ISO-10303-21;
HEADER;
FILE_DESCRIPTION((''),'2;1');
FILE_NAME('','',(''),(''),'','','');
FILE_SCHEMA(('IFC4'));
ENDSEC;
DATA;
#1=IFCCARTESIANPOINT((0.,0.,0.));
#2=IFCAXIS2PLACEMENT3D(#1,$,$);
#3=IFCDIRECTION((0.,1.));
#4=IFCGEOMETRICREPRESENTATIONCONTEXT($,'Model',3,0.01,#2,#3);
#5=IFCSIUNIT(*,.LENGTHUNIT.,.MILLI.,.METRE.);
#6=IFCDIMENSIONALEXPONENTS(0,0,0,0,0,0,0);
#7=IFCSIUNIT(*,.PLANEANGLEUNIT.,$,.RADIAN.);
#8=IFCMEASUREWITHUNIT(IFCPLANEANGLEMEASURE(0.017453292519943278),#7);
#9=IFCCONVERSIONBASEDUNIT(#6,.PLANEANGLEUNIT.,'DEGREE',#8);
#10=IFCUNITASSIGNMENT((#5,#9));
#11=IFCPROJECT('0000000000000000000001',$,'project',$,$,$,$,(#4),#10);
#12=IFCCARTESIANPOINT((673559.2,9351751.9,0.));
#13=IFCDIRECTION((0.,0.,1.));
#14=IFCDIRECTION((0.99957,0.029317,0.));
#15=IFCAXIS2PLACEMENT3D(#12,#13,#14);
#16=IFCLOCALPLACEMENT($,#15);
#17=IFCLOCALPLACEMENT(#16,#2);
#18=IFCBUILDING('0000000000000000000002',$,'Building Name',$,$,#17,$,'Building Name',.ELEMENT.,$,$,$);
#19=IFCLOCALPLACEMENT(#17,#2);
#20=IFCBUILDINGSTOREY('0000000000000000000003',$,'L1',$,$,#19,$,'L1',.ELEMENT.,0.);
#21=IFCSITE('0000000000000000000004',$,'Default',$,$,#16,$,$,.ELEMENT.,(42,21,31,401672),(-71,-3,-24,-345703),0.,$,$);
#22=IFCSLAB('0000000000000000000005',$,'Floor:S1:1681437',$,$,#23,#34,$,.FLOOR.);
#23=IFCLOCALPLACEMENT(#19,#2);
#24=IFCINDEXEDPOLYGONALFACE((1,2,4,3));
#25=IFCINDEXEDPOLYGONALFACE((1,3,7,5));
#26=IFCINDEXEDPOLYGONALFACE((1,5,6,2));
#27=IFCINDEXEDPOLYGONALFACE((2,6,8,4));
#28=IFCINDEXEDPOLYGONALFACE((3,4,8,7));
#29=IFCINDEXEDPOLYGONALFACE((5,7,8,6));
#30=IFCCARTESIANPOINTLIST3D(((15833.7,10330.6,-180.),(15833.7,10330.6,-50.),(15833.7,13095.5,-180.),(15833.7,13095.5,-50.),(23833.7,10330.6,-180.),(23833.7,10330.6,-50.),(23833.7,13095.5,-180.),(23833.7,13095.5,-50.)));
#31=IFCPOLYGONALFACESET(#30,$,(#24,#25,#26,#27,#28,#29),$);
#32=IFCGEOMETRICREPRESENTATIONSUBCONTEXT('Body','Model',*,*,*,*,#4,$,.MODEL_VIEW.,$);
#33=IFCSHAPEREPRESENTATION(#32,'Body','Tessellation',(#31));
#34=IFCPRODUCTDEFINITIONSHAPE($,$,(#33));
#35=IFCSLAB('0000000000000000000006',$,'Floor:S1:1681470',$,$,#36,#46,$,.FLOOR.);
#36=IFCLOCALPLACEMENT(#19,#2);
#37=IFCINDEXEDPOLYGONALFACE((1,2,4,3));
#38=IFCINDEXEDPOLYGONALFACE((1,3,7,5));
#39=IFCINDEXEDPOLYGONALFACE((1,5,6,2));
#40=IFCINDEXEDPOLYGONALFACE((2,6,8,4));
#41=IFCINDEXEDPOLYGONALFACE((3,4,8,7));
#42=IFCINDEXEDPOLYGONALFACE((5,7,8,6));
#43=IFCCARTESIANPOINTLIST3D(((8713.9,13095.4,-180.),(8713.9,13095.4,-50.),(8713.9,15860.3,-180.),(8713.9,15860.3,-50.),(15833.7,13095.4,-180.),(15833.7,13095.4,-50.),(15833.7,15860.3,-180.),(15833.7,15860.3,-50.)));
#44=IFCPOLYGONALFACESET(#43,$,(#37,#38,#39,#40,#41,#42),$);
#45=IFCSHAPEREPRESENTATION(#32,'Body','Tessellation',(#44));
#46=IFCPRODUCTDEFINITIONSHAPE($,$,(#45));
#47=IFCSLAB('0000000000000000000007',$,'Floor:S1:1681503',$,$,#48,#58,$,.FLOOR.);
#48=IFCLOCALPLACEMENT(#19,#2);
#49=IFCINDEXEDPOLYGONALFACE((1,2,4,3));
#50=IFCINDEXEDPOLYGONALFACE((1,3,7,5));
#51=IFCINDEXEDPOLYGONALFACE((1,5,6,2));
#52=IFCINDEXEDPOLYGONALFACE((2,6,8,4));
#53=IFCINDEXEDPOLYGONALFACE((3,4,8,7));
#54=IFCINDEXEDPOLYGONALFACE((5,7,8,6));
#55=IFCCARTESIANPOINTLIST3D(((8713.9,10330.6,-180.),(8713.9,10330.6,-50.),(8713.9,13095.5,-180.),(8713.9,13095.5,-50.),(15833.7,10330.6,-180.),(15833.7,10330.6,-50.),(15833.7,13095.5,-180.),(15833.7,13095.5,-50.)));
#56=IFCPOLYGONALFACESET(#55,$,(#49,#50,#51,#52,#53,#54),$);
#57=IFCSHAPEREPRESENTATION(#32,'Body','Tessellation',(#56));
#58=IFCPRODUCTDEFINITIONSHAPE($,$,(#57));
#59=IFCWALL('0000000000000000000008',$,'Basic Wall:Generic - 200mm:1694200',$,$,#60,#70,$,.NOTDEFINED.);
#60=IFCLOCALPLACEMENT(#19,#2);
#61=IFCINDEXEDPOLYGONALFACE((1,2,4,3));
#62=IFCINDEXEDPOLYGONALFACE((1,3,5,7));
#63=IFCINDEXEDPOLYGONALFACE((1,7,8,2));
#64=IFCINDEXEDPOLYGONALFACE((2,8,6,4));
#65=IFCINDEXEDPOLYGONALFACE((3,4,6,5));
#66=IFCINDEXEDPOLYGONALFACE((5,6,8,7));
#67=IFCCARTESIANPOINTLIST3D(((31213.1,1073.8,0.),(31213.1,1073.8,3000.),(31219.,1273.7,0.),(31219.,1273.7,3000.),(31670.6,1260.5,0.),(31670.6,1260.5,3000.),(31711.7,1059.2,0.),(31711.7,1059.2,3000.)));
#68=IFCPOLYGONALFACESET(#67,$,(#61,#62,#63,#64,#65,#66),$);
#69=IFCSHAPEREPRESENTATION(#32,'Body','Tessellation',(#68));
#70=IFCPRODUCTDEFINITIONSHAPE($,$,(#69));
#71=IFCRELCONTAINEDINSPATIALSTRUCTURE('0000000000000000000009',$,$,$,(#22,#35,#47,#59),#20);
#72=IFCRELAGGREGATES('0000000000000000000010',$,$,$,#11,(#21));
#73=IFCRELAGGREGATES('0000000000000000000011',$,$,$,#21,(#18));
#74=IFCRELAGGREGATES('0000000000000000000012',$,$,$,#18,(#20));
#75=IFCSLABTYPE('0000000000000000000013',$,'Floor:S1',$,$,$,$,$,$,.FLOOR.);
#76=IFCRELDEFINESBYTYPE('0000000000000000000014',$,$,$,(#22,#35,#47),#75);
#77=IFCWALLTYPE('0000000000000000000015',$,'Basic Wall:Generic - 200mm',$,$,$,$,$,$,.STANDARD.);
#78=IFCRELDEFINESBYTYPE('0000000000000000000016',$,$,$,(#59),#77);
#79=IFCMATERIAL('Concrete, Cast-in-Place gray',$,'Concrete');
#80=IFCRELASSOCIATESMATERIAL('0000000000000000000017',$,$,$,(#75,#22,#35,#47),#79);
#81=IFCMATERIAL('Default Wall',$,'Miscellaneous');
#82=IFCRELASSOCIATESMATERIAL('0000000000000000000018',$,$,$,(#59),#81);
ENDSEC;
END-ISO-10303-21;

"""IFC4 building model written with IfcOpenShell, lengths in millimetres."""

from ifc_helpers import new_model, entity, si_unit, converted_unit, direction, frame, origin, place, context, subcontext, project, spatial, indexed_curve, outline, extrude, material, type_object, element, save


model = new_model("IFC4")

# Units and contexts
model_context = context("Model", 3, precision=0.01, world=origin(), true_north=direction((0.0, 1.0)))
body_context = subcontext(model_context, "Body", "Model", "MODEL_VIEW")
ifc_project = project(units=[si_unit("LENGTHUNIT", "METRE", prefix="MILLI"), converted_unit("PLANEANGLEUNIT", "DEGREE", entity("IfcPlaneAngleMeasure", 0.017453292519943278), si_unit("PLANEANGLEUNIT", "RADIAN"), dimensions=[0, 0, 0, 0, 0, 0, 0])], contexts=[model_context])

# Site, building, storey
site_placement = place(None, frame((673559.2, 9351751.9, 0.0), z_axis=(0.0, 0.0, 1.0), x_axis=(0.99957, 0.029317, 0.0)))
site = spatial("IfcSite", under=ifc_project, at=site_placement, Name="Default", CompositionType="ELEMENT", RefLatitude=(42, 21, 31, 401672), RefLongitude=(-71, -3, -24, -345703), RefElevation=0.0)
building_placement = place(site_placement, origin())
building = spatial("IfcBuilding", under=site, at=building_placement, Name="Building Name", LongName="Building Name", CompositionType="ELEMENT")
storey_placement = place(building_placement, origin())
storey = spatial("IfcBuildingStorey", under=building, at=storey_placement, Name="L1", LongName="L1", CompositionType="ELEMENT", Elevation=0.0)

# Shared definitions
ifc_material_1 = material(Name="Concrete, Cast-in-Place gray", Category="Concrete")

# Slabs
slab_type_1 = type_object("IfcSlabType", Name="Floor:S1", PredefinedType="FLOOR", material=ifc_material_1)
slab_1_placement = place(storey_placement, origin())
element("IfcSlab", 1, at=slab_1_placement, inside=storey, type_object=slab_type_1, material=ifc_material_1, Name="Floor:S1:1681437", PredefinedType="FLOOR", context=body_context, shape_type="SweptSolid", body=[
    extrude(outline(indexed_curve([(-1382.4, -4000.0), (1382.4, -4000.0), (1382.4, 4000.0), (-1382.4, 4000.0), (-1382.4, -4000.0)], self_intersect=False)), frame((19833.7, 11713.0, -50.0), z_axis=(0.0, 0.0, -1.0), x_axis=(0.0, 1.0, 0.0)), (0.0, 0.0, 1.0), 130.0),
])
slab_2_placement = place(storey_placement, origin())
element("IfcSlab", 2, at=slab_2_placement, inside=storey, type_object=slab_type_1, material=ifc_material_1, Name="Floor:S1:1681470", PredefinedType="FLOOR", context=body_context, shape_type="SweptSolid", body=[
    extrude(outline(indexed_curve([(-1382.4, -3559.9), (1382.4, -3559.9), (1382.4, 3559.9), (-1382.4, 3559.9), (-1382.4, -3559.9)], self_intersect=False)), frame((12273.8, 14477.9, -50.0), z_axis=(0.0, 0.0, -1.0), x_axis=(0.0, 1.0, 0.0)), (0.0, 0.0, 1.0), 130.0),
])
slab_3_placement = place(storey_placement, origin())
element("IfcSlab", 3, at=slab_3_placement, inside=storey, type_object=slab_type_1, material=ifc_material_1, Name="Floor:S1:1681503", PredefinedType="FLOOR", context=body_context, shape_type="SweptSolid", body=[
    extrude(outline(indexed_curve([(-1382.4, -3559.9), (1382.4, -3559.9), (1382.4, 3559.9), (-1382.4, 3559.9), (-1382.4, -3559.9)], self_intersect=False)), frame((12273.8, 11713.0, -50.0), z_axis=(0.0, 0.0, -1.0), x_axis=(0.0, 1.0, 0.0)), (0.0, 0.0, 1.0), 130.0),
])

# Wall
ifc_material_2 = material(Name="Default Wall", Category="Miscellaneous")
wall_type = type_object("IfcWallType", Name="Basic Wall:Generic - 200mm", PredefinedType="STANDARD")
wall_placement = place(storey_placement, frame((31714.6, 1159.1, 0.0), z_axis=(0.0, 0.0, 1.0), x_axis=(-0.99957, 0.029317, 0.0)))
element("IfcWall", 4, at=wall_placement, inside=storey, type_object=wall_type, material=ifc_material_2, Name="Basic Wall:Generic - 200mm:1694200", PredefinedType="NOTDEFINED", context=body_context, shape_type="SweptSolid", body=[
    extrude(outline(indexed_curve([(498.8, -100.0), (498.8, 100.0), (0.0, 100.0), (47.0, -100.0), (498.8, -100.0)], self_intersect=False)), origin(), (0.0, 0.0, 1.0), 3000.0),
])

save(model, "model.ifc")
